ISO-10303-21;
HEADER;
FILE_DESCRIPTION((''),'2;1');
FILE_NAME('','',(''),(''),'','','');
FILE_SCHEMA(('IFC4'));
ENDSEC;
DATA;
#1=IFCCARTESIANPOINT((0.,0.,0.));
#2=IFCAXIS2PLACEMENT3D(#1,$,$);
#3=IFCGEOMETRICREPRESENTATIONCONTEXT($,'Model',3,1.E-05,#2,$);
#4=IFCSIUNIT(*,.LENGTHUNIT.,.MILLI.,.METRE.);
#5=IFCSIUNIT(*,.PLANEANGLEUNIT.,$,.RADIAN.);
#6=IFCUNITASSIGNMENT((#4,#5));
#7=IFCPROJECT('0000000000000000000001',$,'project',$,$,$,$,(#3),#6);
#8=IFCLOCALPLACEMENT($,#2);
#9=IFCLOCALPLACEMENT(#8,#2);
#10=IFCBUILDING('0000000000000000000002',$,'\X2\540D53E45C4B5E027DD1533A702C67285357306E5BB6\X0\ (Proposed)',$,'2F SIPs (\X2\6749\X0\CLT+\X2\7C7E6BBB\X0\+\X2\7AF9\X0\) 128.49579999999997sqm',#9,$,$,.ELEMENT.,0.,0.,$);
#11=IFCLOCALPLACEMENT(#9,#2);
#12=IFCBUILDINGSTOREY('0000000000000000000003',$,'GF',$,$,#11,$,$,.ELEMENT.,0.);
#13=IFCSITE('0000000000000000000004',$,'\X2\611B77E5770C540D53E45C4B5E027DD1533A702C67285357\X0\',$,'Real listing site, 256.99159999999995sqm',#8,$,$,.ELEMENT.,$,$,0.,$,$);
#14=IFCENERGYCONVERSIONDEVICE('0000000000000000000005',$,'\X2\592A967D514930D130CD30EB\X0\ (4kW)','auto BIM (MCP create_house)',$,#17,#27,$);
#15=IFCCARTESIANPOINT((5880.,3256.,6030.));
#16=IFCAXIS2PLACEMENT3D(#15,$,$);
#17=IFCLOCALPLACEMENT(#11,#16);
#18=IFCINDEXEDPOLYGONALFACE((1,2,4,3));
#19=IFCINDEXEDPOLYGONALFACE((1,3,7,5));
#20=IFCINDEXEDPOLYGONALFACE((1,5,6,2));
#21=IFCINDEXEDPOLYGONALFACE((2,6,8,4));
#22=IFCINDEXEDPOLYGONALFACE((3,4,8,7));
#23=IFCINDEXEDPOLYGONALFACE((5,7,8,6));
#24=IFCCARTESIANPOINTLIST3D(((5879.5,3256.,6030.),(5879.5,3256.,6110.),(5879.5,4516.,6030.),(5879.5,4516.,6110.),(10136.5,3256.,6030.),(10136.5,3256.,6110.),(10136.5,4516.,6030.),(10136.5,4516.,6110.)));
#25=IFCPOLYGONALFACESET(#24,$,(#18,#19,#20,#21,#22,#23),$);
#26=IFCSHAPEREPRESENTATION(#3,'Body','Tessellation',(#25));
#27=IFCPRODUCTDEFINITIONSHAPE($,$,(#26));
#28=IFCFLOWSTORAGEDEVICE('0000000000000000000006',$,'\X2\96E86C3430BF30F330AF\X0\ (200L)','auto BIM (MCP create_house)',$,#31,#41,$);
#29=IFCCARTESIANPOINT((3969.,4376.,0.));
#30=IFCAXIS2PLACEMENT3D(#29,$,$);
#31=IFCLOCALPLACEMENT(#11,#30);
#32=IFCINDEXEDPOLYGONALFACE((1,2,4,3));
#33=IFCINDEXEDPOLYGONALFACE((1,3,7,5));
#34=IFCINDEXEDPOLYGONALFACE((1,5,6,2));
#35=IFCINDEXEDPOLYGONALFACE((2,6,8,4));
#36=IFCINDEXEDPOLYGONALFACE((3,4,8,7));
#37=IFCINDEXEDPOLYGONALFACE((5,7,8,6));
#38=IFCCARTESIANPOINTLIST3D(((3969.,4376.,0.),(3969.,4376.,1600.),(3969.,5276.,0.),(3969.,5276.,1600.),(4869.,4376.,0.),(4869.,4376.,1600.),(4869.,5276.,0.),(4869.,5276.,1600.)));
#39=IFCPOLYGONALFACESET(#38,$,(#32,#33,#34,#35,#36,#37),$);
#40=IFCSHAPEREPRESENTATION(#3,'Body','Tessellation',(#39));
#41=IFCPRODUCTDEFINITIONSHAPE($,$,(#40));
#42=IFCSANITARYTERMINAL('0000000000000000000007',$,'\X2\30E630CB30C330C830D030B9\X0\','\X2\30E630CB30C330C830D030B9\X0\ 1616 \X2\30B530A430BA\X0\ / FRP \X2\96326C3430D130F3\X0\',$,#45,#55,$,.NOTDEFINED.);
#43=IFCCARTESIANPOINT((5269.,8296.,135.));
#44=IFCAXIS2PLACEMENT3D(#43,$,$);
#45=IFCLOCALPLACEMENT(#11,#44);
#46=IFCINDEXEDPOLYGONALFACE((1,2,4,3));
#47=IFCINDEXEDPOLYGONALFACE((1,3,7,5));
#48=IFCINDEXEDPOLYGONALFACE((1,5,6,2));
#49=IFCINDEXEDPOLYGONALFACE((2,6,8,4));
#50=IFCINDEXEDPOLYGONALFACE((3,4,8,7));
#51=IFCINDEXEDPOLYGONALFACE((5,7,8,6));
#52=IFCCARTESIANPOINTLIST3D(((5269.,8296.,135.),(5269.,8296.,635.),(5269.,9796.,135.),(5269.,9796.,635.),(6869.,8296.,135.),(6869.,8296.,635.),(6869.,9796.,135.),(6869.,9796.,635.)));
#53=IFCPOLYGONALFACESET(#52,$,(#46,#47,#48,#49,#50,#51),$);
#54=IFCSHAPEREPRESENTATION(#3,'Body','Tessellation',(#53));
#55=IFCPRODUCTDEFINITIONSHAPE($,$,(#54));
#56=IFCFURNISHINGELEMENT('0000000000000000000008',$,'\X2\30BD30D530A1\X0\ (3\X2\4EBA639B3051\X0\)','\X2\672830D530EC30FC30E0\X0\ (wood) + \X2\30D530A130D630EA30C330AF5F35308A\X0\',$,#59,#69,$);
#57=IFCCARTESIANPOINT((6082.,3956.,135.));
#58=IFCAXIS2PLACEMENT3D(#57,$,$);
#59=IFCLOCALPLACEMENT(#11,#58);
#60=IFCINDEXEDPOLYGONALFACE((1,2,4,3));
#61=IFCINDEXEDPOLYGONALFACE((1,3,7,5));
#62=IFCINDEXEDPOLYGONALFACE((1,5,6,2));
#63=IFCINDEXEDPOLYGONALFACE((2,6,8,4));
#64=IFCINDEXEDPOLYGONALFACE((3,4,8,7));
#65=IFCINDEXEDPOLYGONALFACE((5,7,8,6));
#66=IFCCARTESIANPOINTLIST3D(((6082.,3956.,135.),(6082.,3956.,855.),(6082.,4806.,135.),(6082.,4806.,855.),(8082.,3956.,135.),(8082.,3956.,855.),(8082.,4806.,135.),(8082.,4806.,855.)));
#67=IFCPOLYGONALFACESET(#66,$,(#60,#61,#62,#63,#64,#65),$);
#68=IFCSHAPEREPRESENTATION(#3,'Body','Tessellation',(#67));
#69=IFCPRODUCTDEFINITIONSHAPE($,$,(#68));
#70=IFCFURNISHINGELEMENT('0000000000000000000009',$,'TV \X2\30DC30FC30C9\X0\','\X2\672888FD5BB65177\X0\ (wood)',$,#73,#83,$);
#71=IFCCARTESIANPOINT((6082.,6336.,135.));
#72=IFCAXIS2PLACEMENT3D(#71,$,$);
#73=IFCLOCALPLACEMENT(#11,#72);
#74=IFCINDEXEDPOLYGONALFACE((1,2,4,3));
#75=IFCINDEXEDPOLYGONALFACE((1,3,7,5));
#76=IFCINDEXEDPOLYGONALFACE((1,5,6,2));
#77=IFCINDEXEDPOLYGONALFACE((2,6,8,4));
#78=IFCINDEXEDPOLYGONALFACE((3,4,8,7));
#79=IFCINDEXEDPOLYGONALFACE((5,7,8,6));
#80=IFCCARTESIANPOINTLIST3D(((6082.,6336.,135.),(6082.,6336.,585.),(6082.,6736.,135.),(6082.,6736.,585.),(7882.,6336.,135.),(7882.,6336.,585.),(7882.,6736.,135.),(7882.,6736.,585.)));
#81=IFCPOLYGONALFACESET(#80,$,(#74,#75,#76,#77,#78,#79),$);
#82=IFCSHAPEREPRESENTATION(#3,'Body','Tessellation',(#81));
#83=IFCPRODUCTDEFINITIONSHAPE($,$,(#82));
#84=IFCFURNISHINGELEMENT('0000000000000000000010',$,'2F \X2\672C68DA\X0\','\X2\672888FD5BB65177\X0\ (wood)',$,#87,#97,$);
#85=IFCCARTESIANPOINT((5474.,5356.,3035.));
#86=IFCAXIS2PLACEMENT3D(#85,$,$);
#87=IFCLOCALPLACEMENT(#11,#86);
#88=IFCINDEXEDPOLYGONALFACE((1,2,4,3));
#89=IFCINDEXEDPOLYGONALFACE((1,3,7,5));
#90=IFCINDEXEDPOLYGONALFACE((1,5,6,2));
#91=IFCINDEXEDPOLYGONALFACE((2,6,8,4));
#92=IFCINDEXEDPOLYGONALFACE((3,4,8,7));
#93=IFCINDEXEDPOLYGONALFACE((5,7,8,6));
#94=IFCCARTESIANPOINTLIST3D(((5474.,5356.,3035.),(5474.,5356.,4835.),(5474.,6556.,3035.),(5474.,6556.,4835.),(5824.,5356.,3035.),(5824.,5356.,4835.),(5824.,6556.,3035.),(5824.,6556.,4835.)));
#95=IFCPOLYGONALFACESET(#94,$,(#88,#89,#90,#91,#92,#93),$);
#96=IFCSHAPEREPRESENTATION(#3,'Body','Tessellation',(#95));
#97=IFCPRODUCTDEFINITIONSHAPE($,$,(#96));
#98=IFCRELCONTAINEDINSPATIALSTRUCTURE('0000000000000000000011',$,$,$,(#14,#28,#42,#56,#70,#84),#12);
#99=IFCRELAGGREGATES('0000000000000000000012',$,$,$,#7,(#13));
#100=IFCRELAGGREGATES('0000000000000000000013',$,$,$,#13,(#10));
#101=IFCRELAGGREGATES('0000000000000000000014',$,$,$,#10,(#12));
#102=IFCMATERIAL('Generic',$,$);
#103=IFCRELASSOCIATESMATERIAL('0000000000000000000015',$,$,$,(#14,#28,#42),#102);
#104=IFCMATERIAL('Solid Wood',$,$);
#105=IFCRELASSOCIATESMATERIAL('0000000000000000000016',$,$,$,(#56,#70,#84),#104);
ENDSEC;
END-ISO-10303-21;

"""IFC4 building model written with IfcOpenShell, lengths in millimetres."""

from ifc_helpers import new_model, si_unit, frame, frame_2d, origin, place, context, project, spatial, rectangle, extrude, material, element, save


model = new_model("IFC4")

# Units and contexts
model_context = context("Model", 3, precision=1e-05, world=origin())
ifc_project = project(units=[si_unit("LENGTHUNIT", "METRE", prefix="MILLI"), si_unit("PLANEANGLEUNIT", "RADIAN")], contexts=[model_context])

# Site, building, storey
site_placement = place(None, origin())
site = spatial("IfcSite", under=ifc_project, at=site_placement, Name="愛知県名古屋市緑区瀬木南", ObjectType="Real listing site, 256.99159999999995sqm", CompositionType="ELEMENT", RefElevation=0.0)
building_placement = place(site_placement, origin())
building = spatial("IfcBuilding", under=site, at=building_placement, Name="名古屋市緑区瀬木南の家 (Proposed)", ObjectType="2F SIPs (杉CLT+籾殻+竹) 128.49579999999997sqm", CompositionType="ELEMENT", ElevationOfRefHeight=0.0, ElevationOfTerrain=0.0)
storey_placement = place(building_placement, origin())
storey = spatial("IfcBuildingStorey", under=building, at=storey_placement, Name="GF", CompositionType="ELEMENT", Elevation=0.0)

# Shared definitions
ifc_material_1 = material(Name="Solid Wood")

# Energy conversion device
ifc_material_2 = material(Name="Generic")
energy_conversion_device_placement = place(storey_placement, frame((5880.0, 3256.0, 6030.0)))
element("IfcEnergyConversionDevice", 1, at=energy_conversion_device_placement, inside=storey, material=ifc_material_2, Name="太陽光パネル (4kW)", Description="auto BIM (MCP create_house)", context=model_context, shape_type="SweptSolid", body=[
    extrude(rectangle(XDim=4257.0, YDim=1260.0, at=frame_2d((2128.0, 630.0))), frame((5880.0, 3256.0, 6030.0)), (0.0, 0.0, 1.0), 80.0),
])

# Flow storage device
flow_storage_device_placement = place(storey_placement, frame((3969.0, 4376.0, 0.0)))
element("IfcFlowStorageDevice", 2, at=flow_storage_device_placement, inside=storey, material=ifc_material_2, Name="雨水タンク (200L)", Description="auto BIM (MCP create_house)", context=model_context, shape_type="SweptSolid", body=[
    extrude(rectangle(XDim=900.0, YDim=900.0, at=frame_2d((450.0, 450.0))), frame((3969.0, 4376.0, 0.0)), (0.0, 0.0, 1.0), 1600.0),
])

# Sanitary terminal
sanitary_terminal_placement = place(storey_placement, frame((5269.0, 8296.0, 135.0)))
element("IfcSanitaryTerminal", 3, at=sanitary_terminal_placement, inside=storey, material=ifc_material_2, Name="ユニットバス", Description="ユニットバス 1616 サイズ / FRP 防水パン", PredefinedType="NOTDEFINED", context=model_context, shape_type="SweptSolid", body=[
    extrude(rectangle(XDim=1600.0, YDim=1500.0, at=frame_2d((800.0, 750.0))), frame((5269.0, 8296.0, 135.0)), (0.0, 0.0, 1.0), 500.0),
])

# Furnishing elements
furnishing_1_placement = place(storey_placement, frame((6082.0, 3956.0, 135.0)))
element("IfcFurnishingElement", 4, at=furnishing_1_placement, inside=storey, material=ifc_material_1, Name="ソファ (3人掛け)", Description="木フレーム (wood) + ファブリック張り", context=model_context, shape_type="SweptSolid", body=[
    extrude(rectangle(XDim=2000.0, YDim=850.0, at=frame_2d((1000.0, 425.0))), frame((6082.0, 3956.0, 135.0)), (0.0, 0.0, 1.0), 720.0),
])
furnishing_2_placement = place(storey_placement, frame((6082.0, 6336.0, 135.0)))
element("IfcFurnishingElement", 5, at=furnishing_2_placement, inside=storey, material=ifc_material_1, Name="TV ボード", Description="木製家具 (wood)", context=model_context, shape_type="SweptSolid", body=[
    extrude(rectangle(XDim=1800.0, YDim=400.0, at=frame_2d((900.0, 200.0))), frame((6082.0, 6336.0, 135.0)), (0.0, 0.0, 1.0), 450.0),
])
furnishing_3_placement = place(storey_placement, frame((5474.0, 5356.0, 3035.0)))
element("IfcFurnishingElement", 6, at=furnishing_3_placement, inside=storey, material=ifc_material_1, Name="2F 本棚", Description="木製家具 (wood)", context=model_context, shape_type="SweptSolid", body=[
    extrude(rectangle(XDim=350.0, YDim=1200.0, at=frame_2d((175.0, 600.0))), frame((5474.0, 5356.0, 3035.0)), (0.0, 0.0, 1.0), 1800.0),
])

save(model, "model.ifc")
